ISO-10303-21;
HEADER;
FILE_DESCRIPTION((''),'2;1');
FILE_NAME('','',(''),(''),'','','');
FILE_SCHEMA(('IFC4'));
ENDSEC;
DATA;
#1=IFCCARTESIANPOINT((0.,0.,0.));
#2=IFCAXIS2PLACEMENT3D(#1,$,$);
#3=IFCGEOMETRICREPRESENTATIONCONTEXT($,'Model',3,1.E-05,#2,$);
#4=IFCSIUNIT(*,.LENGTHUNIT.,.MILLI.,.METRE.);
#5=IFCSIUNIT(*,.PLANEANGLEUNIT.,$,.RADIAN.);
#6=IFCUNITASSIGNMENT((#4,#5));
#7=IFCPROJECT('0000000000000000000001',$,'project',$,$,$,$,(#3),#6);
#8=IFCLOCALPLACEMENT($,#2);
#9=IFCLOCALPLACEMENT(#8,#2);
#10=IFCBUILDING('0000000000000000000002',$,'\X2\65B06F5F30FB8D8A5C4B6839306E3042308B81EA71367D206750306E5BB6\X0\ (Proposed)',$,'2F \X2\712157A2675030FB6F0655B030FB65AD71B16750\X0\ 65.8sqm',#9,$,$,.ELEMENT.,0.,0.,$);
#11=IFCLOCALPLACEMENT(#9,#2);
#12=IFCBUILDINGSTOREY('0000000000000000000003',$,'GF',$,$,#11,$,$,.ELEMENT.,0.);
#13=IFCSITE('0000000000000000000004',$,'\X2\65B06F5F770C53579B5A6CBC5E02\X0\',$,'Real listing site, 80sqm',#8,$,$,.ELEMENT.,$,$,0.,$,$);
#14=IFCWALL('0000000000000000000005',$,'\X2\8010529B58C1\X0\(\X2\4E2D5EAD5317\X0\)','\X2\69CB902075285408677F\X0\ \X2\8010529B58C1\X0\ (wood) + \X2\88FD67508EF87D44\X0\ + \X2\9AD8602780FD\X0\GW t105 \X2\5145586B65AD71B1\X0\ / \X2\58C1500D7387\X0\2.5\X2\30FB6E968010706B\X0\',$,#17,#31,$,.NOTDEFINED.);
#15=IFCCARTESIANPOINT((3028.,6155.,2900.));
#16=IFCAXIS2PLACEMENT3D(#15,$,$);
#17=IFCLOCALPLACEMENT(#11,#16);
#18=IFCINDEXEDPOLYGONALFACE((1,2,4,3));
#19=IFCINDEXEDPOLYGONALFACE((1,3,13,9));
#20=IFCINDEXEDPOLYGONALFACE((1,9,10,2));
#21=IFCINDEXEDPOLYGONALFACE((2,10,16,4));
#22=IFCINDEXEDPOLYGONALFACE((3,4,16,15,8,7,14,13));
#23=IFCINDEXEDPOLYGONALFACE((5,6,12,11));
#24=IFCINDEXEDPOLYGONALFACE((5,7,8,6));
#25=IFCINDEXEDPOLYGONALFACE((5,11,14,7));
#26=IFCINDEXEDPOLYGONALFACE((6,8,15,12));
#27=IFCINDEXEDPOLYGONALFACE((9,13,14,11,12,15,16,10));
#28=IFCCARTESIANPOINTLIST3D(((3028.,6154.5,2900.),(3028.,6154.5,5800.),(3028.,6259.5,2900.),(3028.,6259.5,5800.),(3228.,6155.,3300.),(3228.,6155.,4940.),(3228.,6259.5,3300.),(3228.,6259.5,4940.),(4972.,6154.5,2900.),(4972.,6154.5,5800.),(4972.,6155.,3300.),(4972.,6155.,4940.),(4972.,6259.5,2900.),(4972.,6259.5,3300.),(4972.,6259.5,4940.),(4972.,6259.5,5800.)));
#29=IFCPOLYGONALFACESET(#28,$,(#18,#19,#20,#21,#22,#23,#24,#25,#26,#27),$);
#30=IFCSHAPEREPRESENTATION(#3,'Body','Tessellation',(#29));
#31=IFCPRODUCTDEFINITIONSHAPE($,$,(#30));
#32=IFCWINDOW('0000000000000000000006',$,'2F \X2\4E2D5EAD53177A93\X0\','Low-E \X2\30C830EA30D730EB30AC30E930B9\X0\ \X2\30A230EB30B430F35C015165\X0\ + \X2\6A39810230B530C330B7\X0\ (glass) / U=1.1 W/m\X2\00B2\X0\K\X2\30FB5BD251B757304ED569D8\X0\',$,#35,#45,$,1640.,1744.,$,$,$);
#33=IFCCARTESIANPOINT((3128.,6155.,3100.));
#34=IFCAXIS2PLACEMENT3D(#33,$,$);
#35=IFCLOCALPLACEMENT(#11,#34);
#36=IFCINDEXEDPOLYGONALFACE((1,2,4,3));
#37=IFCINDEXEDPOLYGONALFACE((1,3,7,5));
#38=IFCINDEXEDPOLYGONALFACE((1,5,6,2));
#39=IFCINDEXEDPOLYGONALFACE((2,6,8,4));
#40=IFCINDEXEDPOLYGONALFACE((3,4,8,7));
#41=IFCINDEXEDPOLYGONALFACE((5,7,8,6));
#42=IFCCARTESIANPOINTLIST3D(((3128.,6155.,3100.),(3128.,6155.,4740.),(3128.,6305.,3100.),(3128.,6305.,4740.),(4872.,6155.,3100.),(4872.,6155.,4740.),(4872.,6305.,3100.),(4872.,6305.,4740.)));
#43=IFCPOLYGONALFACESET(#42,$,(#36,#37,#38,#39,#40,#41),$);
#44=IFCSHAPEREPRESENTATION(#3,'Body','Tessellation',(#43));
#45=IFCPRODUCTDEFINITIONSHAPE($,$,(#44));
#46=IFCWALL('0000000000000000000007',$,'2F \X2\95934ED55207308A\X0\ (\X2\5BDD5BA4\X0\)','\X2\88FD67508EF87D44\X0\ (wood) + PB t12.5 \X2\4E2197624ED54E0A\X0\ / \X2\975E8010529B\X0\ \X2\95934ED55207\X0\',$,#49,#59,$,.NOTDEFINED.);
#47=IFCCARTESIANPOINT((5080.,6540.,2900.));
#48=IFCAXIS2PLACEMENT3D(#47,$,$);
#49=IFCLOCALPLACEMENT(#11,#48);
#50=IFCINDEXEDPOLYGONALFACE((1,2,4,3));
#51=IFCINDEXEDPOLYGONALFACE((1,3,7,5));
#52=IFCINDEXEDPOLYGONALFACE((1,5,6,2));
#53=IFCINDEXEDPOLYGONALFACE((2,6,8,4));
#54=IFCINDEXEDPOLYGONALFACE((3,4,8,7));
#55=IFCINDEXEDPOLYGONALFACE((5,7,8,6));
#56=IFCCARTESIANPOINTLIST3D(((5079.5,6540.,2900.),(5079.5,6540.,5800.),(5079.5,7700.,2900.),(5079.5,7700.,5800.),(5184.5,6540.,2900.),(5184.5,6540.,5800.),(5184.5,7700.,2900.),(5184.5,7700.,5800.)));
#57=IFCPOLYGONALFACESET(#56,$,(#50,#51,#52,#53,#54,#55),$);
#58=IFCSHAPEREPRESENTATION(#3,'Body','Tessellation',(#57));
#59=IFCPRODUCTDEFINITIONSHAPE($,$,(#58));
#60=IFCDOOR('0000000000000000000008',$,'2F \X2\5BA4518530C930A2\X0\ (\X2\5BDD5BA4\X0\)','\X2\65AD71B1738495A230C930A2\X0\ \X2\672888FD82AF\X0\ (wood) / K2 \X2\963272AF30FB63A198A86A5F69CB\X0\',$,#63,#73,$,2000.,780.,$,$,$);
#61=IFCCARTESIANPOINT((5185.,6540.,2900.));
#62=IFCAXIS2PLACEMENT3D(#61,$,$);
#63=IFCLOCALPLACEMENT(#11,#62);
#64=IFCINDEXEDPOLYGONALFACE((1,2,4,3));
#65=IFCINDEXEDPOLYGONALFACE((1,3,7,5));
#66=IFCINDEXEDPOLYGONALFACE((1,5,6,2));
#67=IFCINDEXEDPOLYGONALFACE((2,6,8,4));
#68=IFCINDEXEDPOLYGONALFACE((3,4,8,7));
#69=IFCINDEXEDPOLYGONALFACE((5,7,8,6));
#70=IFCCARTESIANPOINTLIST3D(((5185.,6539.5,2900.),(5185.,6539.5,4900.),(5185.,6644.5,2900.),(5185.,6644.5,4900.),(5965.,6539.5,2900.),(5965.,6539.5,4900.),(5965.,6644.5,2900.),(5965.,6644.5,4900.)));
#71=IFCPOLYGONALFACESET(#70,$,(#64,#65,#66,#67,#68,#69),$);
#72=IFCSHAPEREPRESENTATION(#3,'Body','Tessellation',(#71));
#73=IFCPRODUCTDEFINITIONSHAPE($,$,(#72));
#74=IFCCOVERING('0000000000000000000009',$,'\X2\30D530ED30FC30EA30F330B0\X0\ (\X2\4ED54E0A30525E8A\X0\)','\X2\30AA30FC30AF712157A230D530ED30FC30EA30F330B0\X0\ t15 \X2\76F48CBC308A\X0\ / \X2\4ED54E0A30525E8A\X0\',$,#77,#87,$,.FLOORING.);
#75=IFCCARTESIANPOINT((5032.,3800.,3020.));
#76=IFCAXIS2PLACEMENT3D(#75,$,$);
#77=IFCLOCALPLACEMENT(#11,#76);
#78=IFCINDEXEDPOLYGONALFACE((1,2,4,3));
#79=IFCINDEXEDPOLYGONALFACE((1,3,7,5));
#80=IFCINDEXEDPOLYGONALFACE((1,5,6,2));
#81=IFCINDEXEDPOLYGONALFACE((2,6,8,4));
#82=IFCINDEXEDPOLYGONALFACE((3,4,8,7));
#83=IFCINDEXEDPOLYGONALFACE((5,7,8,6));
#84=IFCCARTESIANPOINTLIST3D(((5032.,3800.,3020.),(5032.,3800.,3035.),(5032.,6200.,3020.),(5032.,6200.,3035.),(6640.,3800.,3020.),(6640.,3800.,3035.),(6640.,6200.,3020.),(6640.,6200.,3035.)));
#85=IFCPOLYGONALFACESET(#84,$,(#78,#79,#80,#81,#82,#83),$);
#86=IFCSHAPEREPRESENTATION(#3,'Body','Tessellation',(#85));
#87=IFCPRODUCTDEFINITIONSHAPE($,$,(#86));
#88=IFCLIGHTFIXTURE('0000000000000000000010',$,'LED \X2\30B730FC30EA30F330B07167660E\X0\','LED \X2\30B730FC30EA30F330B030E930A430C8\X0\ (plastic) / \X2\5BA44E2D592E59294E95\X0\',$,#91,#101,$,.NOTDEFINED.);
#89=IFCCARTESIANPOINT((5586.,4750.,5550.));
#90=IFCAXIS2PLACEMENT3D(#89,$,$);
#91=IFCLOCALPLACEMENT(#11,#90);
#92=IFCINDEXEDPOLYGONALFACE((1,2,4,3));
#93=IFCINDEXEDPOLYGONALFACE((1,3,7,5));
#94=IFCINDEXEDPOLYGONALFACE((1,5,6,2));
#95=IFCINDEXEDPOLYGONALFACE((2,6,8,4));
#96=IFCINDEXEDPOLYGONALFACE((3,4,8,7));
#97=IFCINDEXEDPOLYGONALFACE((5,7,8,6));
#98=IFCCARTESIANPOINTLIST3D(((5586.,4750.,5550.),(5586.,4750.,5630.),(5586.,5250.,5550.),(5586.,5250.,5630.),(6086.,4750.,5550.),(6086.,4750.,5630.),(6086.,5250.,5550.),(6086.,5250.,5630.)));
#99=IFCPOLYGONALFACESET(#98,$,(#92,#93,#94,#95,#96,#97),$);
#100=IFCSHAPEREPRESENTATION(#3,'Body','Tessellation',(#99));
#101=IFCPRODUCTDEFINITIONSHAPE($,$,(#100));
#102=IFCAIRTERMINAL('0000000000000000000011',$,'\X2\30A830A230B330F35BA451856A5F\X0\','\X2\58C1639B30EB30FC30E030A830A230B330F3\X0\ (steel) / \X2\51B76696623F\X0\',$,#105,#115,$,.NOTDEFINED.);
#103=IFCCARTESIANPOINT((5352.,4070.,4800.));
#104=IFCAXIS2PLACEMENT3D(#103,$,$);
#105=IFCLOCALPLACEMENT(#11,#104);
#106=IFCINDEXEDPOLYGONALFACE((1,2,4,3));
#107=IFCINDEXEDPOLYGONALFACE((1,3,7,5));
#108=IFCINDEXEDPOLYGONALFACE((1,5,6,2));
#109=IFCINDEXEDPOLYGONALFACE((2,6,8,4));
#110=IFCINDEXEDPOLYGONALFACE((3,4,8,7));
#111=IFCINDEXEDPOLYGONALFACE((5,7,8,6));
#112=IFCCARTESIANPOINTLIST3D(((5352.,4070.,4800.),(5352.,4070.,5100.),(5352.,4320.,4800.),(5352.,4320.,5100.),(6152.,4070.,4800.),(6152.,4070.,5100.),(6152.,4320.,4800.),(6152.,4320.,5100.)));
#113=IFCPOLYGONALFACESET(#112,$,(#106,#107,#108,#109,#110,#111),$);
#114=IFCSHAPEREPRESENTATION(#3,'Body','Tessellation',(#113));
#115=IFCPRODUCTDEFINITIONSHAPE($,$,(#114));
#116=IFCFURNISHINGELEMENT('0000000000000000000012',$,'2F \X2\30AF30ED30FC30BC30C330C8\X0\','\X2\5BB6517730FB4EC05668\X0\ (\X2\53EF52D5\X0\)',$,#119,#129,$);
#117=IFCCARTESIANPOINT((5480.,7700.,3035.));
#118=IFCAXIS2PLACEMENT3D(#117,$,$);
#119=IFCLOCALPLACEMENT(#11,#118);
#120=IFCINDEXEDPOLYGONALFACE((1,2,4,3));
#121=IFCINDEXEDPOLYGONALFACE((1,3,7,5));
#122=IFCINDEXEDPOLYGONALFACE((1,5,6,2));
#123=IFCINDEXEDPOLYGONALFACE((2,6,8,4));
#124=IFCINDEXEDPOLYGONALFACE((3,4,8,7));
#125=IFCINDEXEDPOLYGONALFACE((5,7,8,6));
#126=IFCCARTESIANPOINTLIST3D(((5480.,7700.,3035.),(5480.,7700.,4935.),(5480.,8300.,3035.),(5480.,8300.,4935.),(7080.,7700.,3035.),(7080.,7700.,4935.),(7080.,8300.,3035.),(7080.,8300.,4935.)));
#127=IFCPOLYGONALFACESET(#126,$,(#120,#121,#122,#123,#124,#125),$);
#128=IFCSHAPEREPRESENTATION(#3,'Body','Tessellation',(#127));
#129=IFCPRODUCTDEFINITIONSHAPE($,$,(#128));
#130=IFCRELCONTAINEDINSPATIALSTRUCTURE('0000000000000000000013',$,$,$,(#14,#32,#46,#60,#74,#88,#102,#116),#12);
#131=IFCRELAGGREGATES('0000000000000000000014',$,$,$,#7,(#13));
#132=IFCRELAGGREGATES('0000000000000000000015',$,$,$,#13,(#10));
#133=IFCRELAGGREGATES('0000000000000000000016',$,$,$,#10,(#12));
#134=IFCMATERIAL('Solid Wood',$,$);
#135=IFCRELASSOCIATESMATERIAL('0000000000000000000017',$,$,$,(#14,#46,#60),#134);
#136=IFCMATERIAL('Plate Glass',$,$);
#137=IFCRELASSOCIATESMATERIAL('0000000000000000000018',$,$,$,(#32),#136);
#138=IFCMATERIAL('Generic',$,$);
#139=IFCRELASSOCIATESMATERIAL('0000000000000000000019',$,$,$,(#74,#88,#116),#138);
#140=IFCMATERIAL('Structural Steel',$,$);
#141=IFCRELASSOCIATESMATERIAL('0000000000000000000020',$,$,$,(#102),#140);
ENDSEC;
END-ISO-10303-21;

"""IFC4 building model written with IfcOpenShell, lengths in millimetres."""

from ifc_helpers import new_model, si_unit, frame, frame_2d, origin, place, context, project, spatial, rectangle, extrude, material, element, fill, save


model = new_model("IFC4")

# Units and contexts
model_context = context("Model", 3, precision=1e-05, world=origin())
ifc_project = project(units=[si_unit("LENGTHUNIT", "METRE", prefix="MILLI"), si_unit("PLANEANGLEUNIT", "RADIAN")], contexts=[model_context])

# Site, building, storey
site_placement = place(None, origin())
site = spatial("IfcSite", under=ifc_project, at=site_placement, Name="新潟県南魚沼市", ObjectType="Real listing site, 80sqm", CompositionType="ELEMENT", RefElevation=0.0)
building_placement = place(site_placement, origin())
building = spatial("IfcBuilding", under=site, at=building_placement, Name="新潟・越屋根のある自然素材の家 (Proposed)", ObjectType="2F 無垢材・漆喰・断熱材 65.8sqm", CompositionType="ELEMENT", ElevationOfRefHeight=0.0, ElevationOfTerrain=0.0)
storey_placement = place(building_placement, origin())
storey = spatial("IfcBuildingStorey", under=building, at=storey_placement, Name="GF", CompositionType="ELEMENT", Elevation=0.0)

# Shared definitions
ifc_material_1 = material(Name="Solid Wood")

# Wall, opening, window
wall_1_placement = place(storey_placement, frame((3028.0, 6155.0, 2900.0)))
wall_1 = element("IfcWall", 1, at=wall_1_placement, inside=storey, material=ifc_material_1, Name="耐力壁(中庭北)", Description="構造用合板 耐力壁 (wood) + 製材軸組 + 高性能GW t105 充填断熱 / 壁倍率2.5・準耐火", PredefinedType="NOTDEFINED", context=model_context, shape_type="SweptSolid", body=[
    extrude(rectangle(XDim=1944.0, YDim=105.0, at=frame_2d((972.0, 52.0))), frame((3028.0, 6155.0, 2900.0)), (0.0, 0.0, 1.0), 2900.0),
])
opening_placement = place(storey_placement, frame((3128.0, 6155.0, 3100.0)))
opening = element("IfcOpeningElement", 2, at=opening_placement, cuts=wall_1, PredefinedType="NOTDEFINED", context=model_context, shape_type="SweptSolid", body=[
    extrude(rectangle(XDim=1744.0, YDim=150.0, at=frame_2d((872.0, 75.0))), frame((3128.0, 6155.0, 3100.0)), (0.0, 0.0, 1.0), 1640.0),
])
ifc_material_2 = material(Name="Plate Glass")
window_placement = place(storey_placement, frame((3128.0, 6155.0, 3100.0)))
window = element("IfcWindow", 3, at=window_placement, inside=storey, material=ifc_material_2, Name="2F 中庭北窓", Description="Low-E トリプルガラス アルゴン封入 + 樹脂サッシ (glass) / U=1.1 W/m²K・寒冷地仕様", OverallHeight=1640.0, OverallWidth=1744.0, context=model_context, shape_type="SweptSolid", body=[
    extrude(rectangle(XDim=1744.0, YDim=150.0, at=frame_2d((872.0, 75.0))), frame((3128.0, 6155.0, 3100.0)), (0.0, 0.0, 1.0), 1640.0),
])
fill(opening, window)

# Wall
wall_2_placement = place(storey_placement, frame((5080.0, 6540.0, 2900.0)))
element("IfcWall", 4, at=wall_2_placement, inside=storey, material=ifc_material_1, Name="2F 間仕切り (寝室)", Description="製材軸組 (wood) + PB t12.5 両面仕上 / 非耐力 間仕切", PredefinedType="NOTDEFINED", context=model_context, shape_type="SweptSolid", body=[
    extrude(rectangle(XDim=105.0, YDim=1160.0, at=frame_2d((52.0, 580.0))), frame((5080.0, 6540.0, 2900.0)), (0.0, 0.0, 1.0), 2900.0),
])

# Door
door_placement = place(storey_placement, frame((5185.0, 6540.0, 2900.0)))
element("IfcDoor", 5, at=door_placement, inside=storey, material=ifc_material_1, Name="2F 室内ドア (寝室)", Description="断熱玄関ドア 木製芯 (wood) / K2 防犯・採風機構", OverallHeight=2000.0, OverallWidth=780.0, context=model_context, shape_type="SweptSolid", body=[
    extrude(rectangle(XDim=780.0, YDim=105.0, at=frame_2d((390.0, 52.0))), frame((5185.0, 6540.0, 2900.0)), (0.0, 0.0, 1.0), 2000.0),
])

# Covering
ifc_material_3 = material(Name="Generic")
covering_placement = place(storey_placement, frame((5032.0, 3800.0, 3020.0)))
element("IfcCovering", 6, at=covering_placement, inside=storey, material=ifc_material_3, Name="フローリング (仕上げ床)", Description="オーク無垢フローリング t15 直貼り / 仕上げ床", PredefinedType="FLOORING", context=model_context, shape_type="SweptSolid", body=[
    extrude(rectangle(XDim=1608.0, YDim=2400.0, at=frame_2d((804.0, 1200.0))), frame((5032.0, 3800.0, 3020.0)), (0.0, 0.0, 1.0), 15.0),
])

# Light fixture
light_fixture_placement = place(storey_placement, frame((5586.0, 4750.0, 5550.0)))
element("IfcLightFixture", 7, at=light_fixture_placement, inside=storey, material=ifc_material_3, Name="LED シーリング照明", Description="LED シーリングライト (plastic) / 室中央天井", PredefinedType="NOTDEFINED", context=model_context, shape_type="SweptSolid", body=[
    extrude(rectangle(XDim=500.0, YDim=500.0, at=frame_2d((250.0, 250.0))), frame((5586.0, 4750.0, 5550.0)), (0.0, 0.0, 1.0), 80.0),
])

# Air terminal
ifc_material_4 = material(Name="Structural Steel")
air_terminal_placement = place(storey_placement, frame((5352.0, 4070.0, 4800.0)))
element("IfcAirTerminal", 8, at=air_terminal_placement, inside=storey, material=ifc_material_4, Name="エアコン室内機", Description="壁掛ルームエアコン (steel) / 冷暖房", PredefinedType="NOTDEFINED", context=model_context, shape_type="SweptSolid", body=[
    extrude(rectangle(XDim=800.0, YDim=250.0, at=frame_2d((400.0, 125.0))), frame((5352.0, 4070.0, 4800.0)), (0.0, 0.0, 1.0), 300.0),
])

# Furnishing element
furnishing_placement = place(storey_placement, frame((5480.0, 7700.0, 3035.0)))
element("IfcFurnishingElement", 9, at=furnishing_placement, inside=storey, material=ifc_material_3, Name="2F クローゼット", Description="家具・什器 (可動)", context=model_context, shape_type="SweptSolid", body=[
    extrude(rectangle(XDim=1600.0, YDim=600.0, at=frame_2d((800.0, 300.0))), frame((5480.0, 7700.0, 3035.0)), (0.0, 0.0, 1.0), 1900.0),
])

save(model, "model.ifc")
